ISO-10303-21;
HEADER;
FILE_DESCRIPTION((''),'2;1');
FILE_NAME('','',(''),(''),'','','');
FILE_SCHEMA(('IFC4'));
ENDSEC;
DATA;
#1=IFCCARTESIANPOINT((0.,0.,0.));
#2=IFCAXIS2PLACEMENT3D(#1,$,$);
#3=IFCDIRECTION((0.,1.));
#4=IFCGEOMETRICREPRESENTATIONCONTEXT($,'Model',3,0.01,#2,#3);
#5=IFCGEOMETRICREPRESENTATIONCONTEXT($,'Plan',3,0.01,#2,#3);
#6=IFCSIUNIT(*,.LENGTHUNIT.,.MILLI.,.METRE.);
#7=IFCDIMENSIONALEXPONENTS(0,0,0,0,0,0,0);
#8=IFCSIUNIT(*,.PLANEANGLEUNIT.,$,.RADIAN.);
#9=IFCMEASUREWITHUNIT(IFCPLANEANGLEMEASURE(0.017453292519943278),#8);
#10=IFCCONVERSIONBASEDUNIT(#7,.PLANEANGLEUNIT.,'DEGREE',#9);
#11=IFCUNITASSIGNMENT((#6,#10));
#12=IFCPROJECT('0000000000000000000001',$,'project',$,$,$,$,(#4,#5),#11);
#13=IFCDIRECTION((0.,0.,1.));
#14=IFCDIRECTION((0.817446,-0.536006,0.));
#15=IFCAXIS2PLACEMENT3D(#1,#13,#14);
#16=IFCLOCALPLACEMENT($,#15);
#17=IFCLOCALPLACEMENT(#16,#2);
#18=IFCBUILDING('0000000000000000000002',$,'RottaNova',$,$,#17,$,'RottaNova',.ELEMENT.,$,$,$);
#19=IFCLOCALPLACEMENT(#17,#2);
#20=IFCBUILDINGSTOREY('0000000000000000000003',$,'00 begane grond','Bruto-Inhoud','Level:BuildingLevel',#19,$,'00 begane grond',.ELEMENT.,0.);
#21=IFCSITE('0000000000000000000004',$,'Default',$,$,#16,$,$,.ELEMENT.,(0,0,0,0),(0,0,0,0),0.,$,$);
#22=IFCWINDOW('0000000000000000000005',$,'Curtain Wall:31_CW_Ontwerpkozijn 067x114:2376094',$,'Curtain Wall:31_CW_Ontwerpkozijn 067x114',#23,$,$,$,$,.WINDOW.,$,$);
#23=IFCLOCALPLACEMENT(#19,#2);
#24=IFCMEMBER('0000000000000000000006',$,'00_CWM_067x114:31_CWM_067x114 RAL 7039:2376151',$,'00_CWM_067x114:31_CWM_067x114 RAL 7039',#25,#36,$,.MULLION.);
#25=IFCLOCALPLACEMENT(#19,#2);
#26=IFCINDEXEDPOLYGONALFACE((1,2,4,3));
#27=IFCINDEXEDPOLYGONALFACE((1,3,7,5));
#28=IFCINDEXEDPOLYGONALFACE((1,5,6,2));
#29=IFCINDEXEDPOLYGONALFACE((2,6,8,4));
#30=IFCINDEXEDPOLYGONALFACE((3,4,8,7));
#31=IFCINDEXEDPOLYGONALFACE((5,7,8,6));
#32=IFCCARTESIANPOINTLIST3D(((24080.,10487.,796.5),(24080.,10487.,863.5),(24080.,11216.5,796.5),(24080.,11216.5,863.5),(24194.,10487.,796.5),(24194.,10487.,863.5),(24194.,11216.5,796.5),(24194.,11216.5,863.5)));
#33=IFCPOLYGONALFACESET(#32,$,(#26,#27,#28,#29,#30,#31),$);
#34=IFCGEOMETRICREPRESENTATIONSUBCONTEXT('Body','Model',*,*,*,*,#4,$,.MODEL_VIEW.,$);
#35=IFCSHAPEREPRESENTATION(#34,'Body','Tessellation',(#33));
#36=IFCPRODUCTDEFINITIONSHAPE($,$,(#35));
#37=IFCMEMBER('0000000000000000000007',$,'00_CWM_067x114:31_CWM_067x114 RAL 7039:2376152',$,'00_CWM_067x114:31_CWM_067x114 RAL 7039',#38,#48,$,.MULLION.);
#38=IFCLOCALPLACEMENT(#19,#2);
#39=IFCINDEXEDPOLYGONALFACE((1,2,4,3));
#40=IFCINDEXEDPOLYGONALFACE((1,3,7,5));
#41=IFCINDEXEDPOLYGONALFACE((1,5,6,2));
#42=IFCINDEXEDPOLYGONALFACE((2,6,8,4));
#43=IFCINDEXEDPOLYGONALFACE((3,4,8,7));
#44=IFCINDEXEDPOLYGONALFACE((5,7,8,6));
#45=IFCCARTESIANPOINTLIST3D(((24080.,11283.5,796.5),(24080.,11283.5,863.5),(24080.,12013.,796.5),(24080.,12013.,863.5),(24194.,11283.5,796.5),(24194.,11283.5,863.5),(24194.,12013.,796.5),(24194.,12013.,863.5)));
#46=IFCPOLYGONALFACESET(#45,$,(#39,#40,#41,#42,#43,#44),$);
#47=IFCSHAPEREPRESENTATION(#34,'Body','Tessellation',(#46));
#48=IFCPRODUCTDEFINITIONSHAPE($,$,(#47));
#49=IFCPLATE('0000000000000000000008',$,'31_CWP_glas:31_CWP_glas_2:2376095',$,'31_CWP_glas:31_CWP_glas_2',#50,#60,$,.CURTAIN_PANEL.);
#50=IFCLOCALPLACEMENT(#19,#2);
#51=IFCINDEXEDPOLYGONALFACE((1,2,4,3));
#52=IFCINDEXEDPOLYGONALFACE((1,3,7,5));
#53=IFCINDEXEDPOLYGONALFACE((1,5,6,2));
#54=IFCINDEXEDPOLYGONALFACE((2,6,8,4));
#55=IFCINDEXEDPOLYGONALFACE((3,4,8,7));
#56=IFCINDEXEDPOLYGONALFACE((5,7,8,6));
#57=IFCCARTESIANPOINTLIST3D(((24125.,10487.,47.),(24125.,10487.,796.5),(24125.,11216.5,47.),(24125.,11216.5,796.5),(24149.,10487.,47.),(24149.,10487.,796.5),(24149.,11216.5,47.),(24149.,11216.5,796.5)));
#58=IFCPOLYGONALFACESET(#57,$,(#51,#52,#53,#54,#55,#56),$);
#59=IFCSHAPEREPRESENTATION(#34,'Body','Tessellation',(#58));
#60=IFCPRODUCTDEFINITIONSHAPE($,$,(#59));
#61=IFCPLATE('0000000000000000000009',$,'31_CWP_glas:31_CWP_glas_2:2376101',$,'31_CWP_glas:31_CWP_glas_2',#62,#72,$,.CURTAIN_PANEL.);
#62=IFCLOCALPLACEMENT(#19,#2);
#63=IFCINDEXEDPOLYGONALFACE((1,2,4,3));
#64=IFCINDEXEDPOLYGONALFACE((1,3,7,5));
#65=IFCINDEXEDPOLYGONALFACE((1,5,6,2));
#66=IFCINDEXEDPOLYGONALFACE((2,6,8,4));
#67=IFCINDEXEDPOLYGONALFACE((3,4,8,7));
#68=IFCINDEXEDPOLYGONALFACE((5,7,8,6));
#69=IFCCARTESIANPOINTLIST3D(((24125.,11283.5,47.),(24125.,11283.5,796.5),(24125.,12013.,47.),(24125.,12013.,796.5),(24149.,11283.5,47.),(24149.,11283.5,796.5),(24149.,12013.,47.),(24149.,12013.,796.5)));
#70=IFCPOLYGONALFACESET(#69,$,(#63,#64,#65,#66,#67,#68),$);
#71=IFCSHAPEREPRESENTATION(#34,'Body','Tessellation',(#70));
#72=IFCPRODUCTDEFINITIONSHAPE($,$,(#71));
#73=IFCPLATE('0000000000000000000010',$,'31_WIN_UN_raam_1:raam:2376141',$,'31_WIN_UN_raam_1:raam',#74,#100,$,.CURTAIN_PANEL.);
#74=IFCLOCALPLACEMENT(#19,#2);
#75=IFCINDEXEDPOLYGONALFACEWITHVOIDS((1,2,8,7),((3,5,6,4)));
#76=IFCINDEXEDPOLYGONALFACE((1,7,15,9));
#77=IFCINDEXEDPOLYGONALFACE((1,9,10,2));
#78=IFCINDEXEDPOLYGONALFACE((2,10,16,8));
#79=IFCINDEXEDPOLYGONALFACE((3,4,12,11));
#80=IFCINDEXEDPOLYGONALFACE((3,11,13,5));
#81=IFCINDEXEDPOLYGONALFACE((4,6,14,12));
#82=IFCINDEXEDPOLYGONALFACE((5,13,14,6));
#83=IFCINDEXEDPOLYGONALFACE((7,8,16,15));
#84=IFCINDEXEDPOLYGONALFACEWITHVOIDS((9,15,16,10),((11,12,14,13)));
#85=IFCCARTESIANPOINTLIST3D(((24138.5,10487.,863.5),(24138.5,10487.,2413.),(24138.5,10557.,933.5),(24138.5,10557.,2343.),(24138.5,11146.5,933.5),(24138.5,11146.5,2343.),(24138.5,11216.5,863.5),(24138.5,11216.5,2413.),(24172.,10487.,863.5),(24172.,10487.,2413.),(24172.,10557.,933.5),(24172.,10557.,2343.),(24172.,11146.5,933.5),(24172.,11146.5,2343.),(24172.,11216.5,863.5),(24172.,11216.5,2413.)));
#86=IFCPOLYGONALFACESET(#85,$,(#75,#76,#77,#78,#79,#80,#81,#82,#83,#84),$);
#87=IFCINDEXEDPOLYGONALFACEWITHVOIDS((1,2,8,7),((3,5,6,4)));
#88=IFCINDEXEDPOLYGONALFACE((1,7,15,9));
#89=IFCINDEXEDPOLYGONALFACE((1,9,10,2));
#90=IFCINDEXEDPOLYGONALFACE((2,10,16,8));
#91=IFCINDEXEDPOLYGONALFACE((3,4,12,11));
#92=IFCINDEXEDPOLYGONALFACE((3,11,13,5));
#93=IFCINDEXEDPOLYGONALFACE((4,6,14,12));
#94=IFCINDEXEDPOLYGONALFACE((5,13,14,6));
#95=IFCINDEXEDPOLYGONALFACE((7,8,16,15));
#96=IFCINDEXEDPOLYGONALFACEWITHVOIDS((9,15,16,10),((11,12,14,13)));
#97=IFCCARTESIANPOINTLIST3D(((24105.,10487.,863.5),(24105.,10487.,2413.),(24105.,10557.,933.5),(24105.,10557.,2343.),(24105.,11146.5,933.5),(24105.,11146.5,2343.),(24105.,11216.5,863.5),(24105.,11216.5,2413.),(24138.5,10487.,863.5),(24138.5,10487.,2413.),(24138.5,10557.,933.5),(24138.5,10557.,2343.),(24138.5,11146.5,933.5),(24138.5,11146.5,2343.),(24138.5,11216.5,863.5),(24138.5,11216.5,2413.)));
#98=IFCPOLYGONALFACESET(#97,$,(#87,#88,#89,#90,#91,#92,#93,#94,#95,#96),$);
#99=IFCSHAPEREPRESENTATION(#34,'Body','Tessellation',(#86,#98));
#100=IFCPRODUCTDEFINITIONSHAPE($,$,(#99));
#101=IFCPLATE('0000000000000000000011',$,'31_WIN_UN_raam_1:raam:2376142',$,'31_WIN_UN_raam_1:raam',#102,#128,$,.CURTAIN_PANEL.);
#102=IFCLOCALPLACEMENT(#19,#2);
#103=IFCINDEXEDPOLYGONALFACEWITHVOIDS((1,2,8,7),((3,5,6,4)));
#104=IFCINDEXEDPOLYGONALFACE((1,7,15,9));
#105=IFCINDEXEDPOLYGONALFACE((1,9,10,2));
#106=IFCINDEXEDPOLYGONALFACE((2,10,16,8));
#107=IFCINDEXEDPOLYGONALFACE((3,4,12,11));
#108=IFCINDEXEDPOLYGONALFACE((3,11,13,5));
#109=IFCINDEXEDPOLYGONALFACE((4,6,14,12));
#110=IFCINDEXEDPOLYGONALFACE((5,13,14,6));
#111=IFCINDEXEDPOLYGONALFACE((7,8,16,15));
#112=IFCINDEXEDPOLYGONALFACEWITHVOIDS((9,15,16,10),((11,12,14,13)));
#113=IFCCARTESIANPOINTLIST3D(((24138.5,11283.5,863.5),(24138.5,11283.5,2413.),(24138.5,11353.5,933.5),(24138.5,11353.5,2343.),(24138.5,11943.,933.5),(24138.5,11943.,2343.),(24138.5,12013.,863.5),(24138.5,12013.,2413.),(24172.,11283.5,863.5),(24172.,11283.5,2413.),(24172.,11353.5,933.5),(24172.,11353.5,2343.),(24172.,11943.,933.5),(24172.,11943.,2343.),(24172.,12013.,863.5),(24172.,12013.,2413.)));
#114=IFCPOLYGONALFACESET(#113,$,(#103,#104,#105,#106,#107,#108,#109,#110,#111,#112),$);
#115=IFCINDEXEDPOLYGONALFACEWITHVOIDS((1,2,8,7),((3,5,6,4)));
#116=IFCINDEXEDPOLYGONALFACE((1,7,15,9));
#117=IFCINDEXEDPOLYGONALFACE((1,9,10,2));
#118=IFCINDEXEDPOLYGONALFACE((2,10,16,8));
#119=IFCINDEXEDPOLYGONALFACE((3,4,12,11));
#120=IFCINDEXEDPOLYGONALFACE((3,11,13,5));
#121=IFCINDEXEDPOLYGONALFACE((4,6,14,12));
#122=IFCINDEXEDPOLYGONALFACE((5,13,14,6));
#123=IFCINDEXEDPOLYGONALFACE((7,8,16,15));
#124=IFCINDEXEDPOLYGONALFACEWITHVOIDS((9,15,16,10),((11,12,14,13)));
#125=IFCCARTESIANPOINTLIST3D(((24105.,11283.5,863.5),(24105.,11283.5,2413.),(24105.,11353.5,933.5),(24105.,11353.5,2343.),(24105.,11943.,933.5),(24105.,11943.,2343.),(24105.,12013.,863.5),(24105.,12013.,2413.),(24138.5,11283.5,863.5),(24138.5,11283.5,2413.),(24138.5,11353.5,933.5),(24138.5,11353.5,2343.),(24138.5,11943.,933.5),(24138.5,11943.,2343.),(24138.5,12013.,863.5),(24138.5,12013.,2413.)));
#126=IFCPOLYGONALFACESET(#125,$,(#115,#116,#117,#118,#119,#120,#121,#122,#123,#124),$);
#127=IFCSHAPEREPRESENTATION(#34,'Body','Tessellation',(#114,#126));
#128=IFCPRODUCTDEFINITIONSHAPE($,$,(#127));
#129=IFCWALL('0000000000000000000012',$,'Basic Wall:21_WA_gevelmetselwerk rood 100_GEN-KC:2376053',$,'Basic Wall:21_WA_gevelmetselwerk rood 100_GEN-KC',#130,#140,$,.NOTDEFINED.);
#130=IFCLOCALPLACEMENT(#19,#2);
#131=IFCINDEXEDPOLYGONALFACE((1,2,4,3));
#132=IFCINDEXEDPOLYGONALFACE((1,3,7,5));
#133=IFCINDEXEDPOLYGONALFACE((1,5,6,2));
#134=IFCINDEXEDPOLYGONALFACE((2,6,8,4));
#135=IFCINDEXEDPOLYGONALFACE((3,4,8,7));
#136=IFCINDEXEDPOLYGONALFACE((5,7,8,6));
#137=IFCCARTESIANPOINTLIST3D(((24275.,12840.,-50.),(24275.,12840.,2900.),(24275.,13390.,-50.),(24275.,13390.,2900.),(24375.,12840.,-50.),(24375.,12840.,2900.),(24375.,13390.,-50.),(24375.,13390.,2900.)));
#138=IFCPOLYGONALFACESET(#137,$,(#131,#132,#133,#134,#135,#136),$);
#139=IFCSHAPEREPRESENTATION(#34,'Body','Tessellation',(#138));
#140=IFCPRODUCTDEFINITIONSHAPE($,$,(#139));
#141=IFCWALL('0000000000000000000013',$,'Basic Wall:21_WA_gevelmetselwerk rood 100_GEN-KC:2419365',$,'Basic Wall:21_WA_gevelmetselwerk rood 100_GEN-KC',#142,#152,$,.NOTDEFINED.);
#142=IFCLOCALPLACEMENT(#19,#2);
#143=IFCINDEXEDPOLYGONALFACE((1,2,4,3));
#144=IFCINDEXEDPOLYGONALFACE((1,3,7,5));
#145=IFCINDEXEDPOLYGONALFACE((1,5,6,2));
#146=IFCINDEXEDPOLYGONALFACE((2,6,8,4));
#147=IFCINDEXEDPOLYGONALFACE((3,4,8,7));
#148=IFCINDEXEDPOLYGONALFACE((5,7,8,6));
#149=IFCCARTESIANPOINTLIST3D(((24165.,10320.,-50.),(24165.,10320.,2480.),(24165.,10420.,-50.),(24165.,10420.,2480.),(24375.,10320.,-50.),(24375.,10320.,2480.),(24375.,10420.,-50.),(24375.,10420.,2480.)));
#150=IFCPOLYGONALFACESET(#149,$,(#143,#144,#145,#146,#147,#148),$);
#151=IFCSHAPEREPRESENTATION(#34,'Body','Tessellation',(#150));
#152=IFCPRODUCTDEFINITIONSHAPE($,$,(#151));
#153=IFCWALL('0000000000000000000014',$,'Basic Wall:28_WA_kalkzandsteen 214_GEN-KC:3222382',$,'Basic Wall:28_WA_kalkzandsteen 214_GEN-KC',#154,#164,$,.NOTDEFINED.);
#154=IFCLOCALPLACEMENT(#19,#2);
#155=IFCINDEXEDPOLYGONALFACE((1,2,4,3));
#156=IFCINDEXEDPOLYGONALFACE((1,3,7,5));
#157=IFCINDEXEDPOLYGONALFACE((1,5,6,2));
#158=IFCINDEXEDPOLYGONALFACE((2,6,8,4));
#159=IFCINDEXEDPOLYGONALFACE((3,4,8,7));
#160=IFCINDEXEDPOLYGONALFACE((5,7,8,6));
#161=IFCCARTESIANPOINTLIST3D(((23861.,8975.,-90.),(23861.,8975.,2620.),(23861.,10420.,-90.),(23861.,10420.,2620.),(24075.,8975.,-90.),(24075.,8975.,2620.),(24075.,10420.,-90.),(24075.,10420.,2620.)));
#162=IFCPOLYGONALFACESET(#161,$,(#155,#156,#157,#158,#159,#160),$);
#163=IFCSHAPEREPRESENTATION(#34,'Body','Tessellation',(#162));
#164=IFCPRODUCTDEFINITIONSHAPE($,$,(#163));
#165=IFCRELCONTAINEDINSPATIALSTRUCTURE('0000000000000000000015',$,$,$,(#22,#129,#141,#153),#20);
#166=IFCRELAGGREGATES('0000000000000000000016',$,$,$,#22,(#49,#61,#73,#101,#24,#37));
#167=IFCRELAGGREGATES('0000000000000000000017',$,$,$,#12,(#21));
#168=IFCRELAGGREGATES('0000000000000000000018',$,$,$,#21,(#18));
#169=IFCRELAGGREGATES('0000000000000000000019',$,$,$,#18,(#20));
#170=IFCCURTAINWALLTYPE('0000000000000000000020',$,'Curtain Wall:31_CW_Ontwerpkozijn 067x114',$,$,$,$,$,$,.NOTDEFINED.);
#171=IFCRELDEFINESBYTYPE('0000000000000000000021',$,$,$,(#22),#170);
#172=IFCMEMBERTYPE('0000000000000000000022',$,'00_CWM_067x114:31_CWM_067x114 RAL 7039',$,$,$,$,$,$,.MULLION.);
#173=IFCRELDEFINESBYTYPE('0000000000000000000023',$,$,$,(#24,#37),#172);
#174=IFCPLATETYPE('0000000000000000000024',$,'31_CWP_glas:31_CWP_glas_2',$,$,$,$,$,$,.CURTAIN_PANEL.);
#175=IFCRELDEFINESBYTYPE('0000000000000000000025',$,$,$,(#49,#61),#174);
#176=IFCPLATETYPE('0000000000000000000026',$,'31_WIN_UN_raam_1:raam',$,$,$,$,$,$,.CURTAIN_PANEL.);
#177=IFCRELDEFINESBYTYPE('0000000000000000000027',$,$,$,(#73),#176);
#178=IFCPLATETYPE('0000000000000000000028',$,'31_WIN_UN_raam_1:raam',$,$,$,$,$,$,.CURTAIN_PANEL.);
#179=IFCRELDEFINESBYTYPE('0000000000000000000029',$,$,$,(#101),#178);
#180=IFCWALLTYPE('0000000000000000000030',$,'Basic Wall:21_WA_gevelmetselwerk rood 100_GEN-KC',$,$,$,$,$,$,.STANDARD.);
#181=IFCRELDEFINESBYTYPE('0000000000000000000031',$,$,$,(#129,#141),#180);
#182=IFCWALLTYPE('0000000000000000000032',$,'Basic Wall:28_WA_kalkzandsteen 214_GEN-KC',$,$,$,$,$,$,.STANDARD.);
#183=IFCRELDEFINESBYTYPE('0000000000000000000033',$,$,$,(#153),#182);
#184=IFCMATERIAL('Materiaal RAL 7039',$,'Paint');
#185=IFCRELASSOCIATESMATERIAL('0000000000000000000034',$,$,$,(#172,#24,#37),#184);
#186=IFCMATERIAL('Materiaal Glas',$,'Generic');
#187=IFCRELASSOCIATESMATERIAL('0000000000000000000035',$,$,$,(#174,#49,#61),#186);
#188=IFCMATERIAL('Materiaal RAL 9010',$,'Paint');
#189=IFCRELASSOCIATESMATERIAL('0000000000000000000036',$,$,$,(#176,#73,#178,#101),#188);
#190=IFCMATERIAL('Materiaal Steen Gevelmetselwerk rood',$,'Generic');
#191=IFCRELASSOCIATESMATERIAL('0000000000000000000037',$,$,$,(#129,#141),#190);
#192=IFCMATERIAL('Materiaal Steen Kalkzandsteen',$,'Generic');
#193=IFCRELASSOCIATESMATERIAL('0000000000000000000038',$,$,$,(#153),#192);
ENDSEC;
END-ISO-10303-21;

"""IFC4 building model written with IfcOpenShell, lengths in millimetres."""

from ifc_helpers import new_model, entity, si_unit, converted_unit, direction, frame, origin, place, context, subcontext, project, spatial, indexed_curve, outline, extrude, source, transform, mapped, material, type_object, type_shapes, element, aggregate, save


model = new_model("IFC4")

# Units and contexts
model_context = context("Model", 3, precision=0.01, world=origin(), true_north=direction((0.0, 1.0)))
plan_context = context("Plan", 3, precision=0.01, world=origin(), true_north=direction((0.0, 1.0)))
body_context = subcontext(model_context, "Body", "Model", "MODEL_VIEW")
ifc_project = project(units=[si_unit("LENGTHUNIT", "METRE", prefix="MILLI"), converted_unit("PLANEANGLEUNIT", "DEGREE", entity("IfcPlaneAngleMeasure", 0.017453292519943278), si_unit("PLANEANGLEUNIT", "RADIAN"), dimensions=[0, 0, 0, 0, 0, 0, 0])], contexts=[model_context, plan_context])

# Site, building, storey
site_placement = place(None, frame((0.0, 0.0, 0.0), z_axis=(0.0, 0.0, 1.0), x_axis=(0.817446, -0.536006, 0.0)))
site = spatial("IfcSite", under=ifc_project, at=site_placement, Name="Default", CompositionType="ELEMENT", RefLatitude=(0, 0, 0, 0), RefLongitude=(0, 0, 0, 0), RefElevation=0.0)
building_placement = place(site_placement, origin())
building = spatial("IfcBuilding", under=site, at=building_placement, Name="RottaNova", LongName="RottaNova", CompositionType="ELEMENT")
storey_placement = place(building_placement, origin())
storey = spatial("IfcBuildingStorey", under=building, at=storey_placement, Name="00 begane grond", Description="Bruto-Inhoud", ObjectType="Level:BuildingLevel", LongName="00 begane grond", CompositionType="ELEMENT", Elevation=0.0)

# Window, members, plates
curtain_wall_type = type_object("IfcCurtainWallType", Name="Curtain Wall:31_CW_Ontwerpkozijn 067x114", PredefinedType="NOTDEFINED")
window_placement = place(storey_placement, origin())
window = element("IfcWindow", 1, at=window_placement, inside=storey, type_object=curtain_wall_type, Name="Curtain Wall:31_CW_Ontwerpkozijn 067x114:2376094", ObjectType="Curtain Wall:31_CW_Ontwerpkozijn 067x114", PredefinedType="WINDOW")
ifc_material_1 = material(Name="Materiaal RAL 7039", Category="Paint")
member_type_1 = type_object("IfcMemberType", Name="00_CWM_067x114:31_CWM_067x114 RAL 7039", PredefinedType="MULLION", material=ifc_material_1)
shared_shape_1 = source(origin(), body_context, "Body", "SweptSolid", [
    extrude(outline(indexed_curve([(-33.5, -57.0), (33.5, -57.0), (33.5, 57.0), (-33.5, 57.0), (-33.5, -57.0)], self_intersect=False)), frame((0.0, 57.0, -729.5), z_axis=(0.0, 0.0, 1.0), x_axis=(-1.0, 0.0, 0.0)), (0.0, 0.0, 1.0), 729.5),
])
type_shapes(member_type_1, [shared_shape_1])
member_1_placement = place(window_placement, frame((24080.0, 11216.5, 830.0), z_axis=(0.0, 1.0, 0.0), x_axis=(0.0, 0.0, 1.0)))
member_1 = element("IfcMember", 2, at=member_1_placement, type_object=member_type_1, material=ifc_material_1, Name="00_CWM_067x114:31_CWM_067x114 RAL 7039:2376151", ObjectType="00_CWM_067x114:31_CWM_067x114 RAL 7039", PredefinedType="MULLION", context=body_context, shape_type="MappedRepresentation", body=[
    mapped(shared_shape_1, transform((0.0, 0.0, 0.0), scale=1.0)),
])
member_2_placement = place(window_placement, frame((24080.0, 12013.0, 830.0), z_axis=(0.0, 1.0, 0.0), x_axis=(0.0, 0.0, 1.0)))
member_2 = element("IfcMember", 3, at=member_2_placement, type_object=member_type_1, material=ifc_material_1, Name="00_CWM_067x114:31_CWM_067x114 RAL 7039:2376152", ObjectType="00_CWM_067x114:31_CWM_067x114 RAL 7039", PredefinedType="MULLION", context=body_context, shape_type="MappedRepresentation", body=[
    mapped(shared_shape_1, transform((0.0, 0.0, 0.0), scale=1.0)),
])
ifc_material_2 = material(Name="Materiaal Glas", Category="Generic")
plate_type_1 = type_object("IfcPlateType", Name="31_CWP_glas:31_CWP_glas_2", PredefinedType="CURTAIN_PANEL", material=ifc_material_2)
shared_shape_2 = source(origin(), body_context, "Body", "SweptSolid", [
    extrude(outline(indexed_curve([(-12.0, -364.7), (12.0, -364.7), (12.0, 364.7), (-12.0, 364.7), (-12.0, -364.7)], self_intersect=False)), frame((0.0, -57.0, 0.0), z_axis=(0.0, 0.0, 1.0), x_axis=(0.0, 1.0, 0.0)), (0.0, 0.0, 1.0), 749.5),
])
type_shapes(plate_type_1, [shared_shape_2])
plate_1_placement = place(window_placement, frame((24080.0, 10851.7, 47.0), z_axis=(0.0, 0.0, 1.0), x_axis=(0.0, 1.0, 0.0)))
plate_1 = element("IfcPlate", 4, at=plate_1_placement, type_object=plate_type_1, material=ifc_material_2, Name="31_CWP_glas:31_CWP_glas_2:2376095", ObjectType="31_CWP_glas:31_CWP_glas_2", PredefinedType="CURTAIN_PANEL", context=body_context, shape_type="MappedRepresentation", body=[
    mapped(shared_shape_2, transform((0.0, 0.0, 0.0), scale=1.0)),
])
plate_2_placement = place(window_placement, frame((24080.0, 11648.2, 47.0), z_axis=(0.0, 0.0, 1.0), x_axis=(0.0, 1.0, 0.0)))
plate_2 = element("IfcPlate", 5, at=plate_2_placement, type_object=plate_type_1, material=ifc_material_2, Name="31_CWP_glas:31_CWP_glas_2:2376101", ObjectType="31_CWP_glas:31_CWP_glas_2", PredefinedType="CURTAIN_PANEL", context=body_context, shape_type="MappedRepresentation", body=[
    mapped(shared_shape_2, transform((0.0, 0.0, 0.0), scale=1.0)),
])
ifc_material_3 = material(Name="Materiaal RAL 9010", Category="Paint")
plate_type_2 = type_object("IfcPlateType", Name="31_WIN_UN_raam_1:raam", PredefinedType="CURTAIN_PANEL", material=ifc_material_3)
shared_shape_3 = source(origin(), body_context, "Body", "SweptSolid", [
    extrude(outline(indexed_curve([(-364.7, -774.7), (364.7, -774.7), (364.7, 774.7), (-364.7, 774.7), (-364.7, -774.7)], self_intersect=False), holes=[indexed_curve([(-294.7, 704.7), (294.7, 704.7), (294.7, -704.8), (-294.7, -704.8), (-294.7, 704.7)], self_intersect=False)]), frame((0.0, -92.0, 774.8), z_axis=(0.0, 1.0, 0.0), x_axis=(1.0, 0.0, 0.0)), (0.0, 0.0, 1.0), 33.5),
    extrude(outline(indexed_curve([(-364.7, -774.7), (364.7, -774.7), (364.7, 774.7), (-364.7, 774.7), (-364.7, -774.7)], self_intersect=False), holes=[indexed_curve([(-294.7, 704.7), (294.7, 704.7), (294.7, -704.8), (-294.7, -704.8), (-294.7, 704.7)], self_intersect=False)]), frame((0.0, -58.5, 774.8), z_axis=(0.0, 1.0, 0.0), x_axis=(1.0, 0.0, 0.0)), (0.0, 0.0, 1.0), 33.5),
])
type_shapes(plate_type_2, [shared_shape_3])
plate_3_placement = place(window_placement, frame((24080.0, 10851.7, 863.5), z_axis=(0.0, 0.0, 1.0), x_axis=(0.0, 1.0, 0.0)))
plate_3 = element("IfcPlate", 6, at=plate_3_placement, type_object=plate_type_2, material=ifc_material_3, Name="31_WIN_UN_raam_1:raam:2376141", ObjectType="31_WIN_UN_raam_1:raam", PredefinedType="CURTAIN_PANEL", context=body_context, shape_type="MappedRepresentation", body=[
    mapped(shared_shape_3, transform((0.0, 0.0, 0.0), scale=1.0)),
])
plate_type_3 = type_object("IfcPlateType", Name="31_WIN_UN_raam_1:raam", PredefinedType="CURTAIN_PANEL", material=ifc_material_3)
shared_shape_4 = source(origin(), body_context, "Body", "SweptSolid", [
    extrude(outline(indexed_curve([(-364.7, -774.7), (364.7, -774.7), (364.7, 774.7), (-364.7, 774.7), (-364.7, -774.7)], self_intersect=False), holes=[indexed_curve([(-294.7, 704.7), (294.7, 704.7), (294.7, -704.8), (-294.7, -704.8), (-294.7, 704.7)], self_intersect=False)]), frame((0.0, -92.0, 774.8), z_axis=(0.0, 1.0, 0.0), x_axis=(1.0, 0.0, 0.0)), (0.0, 0.0, 1.0), 33.5),
    extrude(outline(indexed_curve([(-364.7, -774.7), (364.7, -774.7), (364.7, 774.7), (-364.7, 774.7), (-364.7, -774.7)], self_intersect=False), holes=[indexed_curve([(-294.7, 704.7), (294.7, 704.7), (294.7, -704.8), (-294.7, -704.8), (-294.7, 704.7)], self_intersect=False)]), frame((0.0, -58.5, 774.8), z_axis=(0.0, 1.0, 0.0), x_axis=(1.0, 0.0, 0.0)), (0.0, 0.0, 1.0), 33.5),
])
type_shapes(plate_type_3, [shared_shape_4])
plate_4_placement = place(window_placement, frame((24080.0, 11648.2, 863.5), z_axis=(0.0, 0.0, 1.0), x_axis=(0.0, 1.0, 0.0)))
plate_4 = element("IfcPlate", 7, at=plate_4_placement, type_object=plate_type_3, material=ifc_material_3, Name="31_WIN_UN_raam_1:raam:2376142", ObjectType="31_WIN_UN_raam_1:raam", PredefinedType="CURTAIN_PANEL", context=body_context, shape_type="MappedRepresentation", body=[
    mapped(shared_shape_4, transform((0.0, 0.0, 0.0), scale=1.0)),
])
aggregate(window, [plate_1, plate_2, plate_3, plate_4, member_1, member_2])

# Walls
ifc_material_4 = material(Name="Materiaal Steen Gevelmetselwerk rood", Category="Generic")
wall_type_1 = type_object("IfcWallType", Name="Basic Wall:21_WA_gevelmetselwerk rood 100_GEN-KC", PredefinedType="STANDARD")
wall_1_placement = place(storey_placement, frame((24325.0, 12840.0, -50.0), z_axis=(0.0, 0.0, 1.0), x_axis=(0.0, 1.0, 0.0)))
element("IfcWall", 8, at=wall_1_placement, inside=storey, type_object=wall_type_1, material=ifc_material_4, Name="Basic Wall:21_WA_gevelmetselwerk rood 100_GEN-KC:2376053", ObjectType="Basic Wall:21_WA_gevelmetselwerk rood 100_GEN-KC", PredefinedType="NOTDEFINED", context=body_context, shape_type="SweptSolid", body=[
    extrude(outline(indexed_curve([(550.0, 50.0), (0.0, 50.0), (0.0, -50.0), (550.0, -50.0), (550.0, 50.0)], self_intersect=False)), origin(), (0.0, 0.0, 1.0), 2950.0),
])
wall_2_placement = place(storey_placement, frame((24375.0, 10370.0, -50.0), z_axis=(0.0, 0.0, 1.0), x_axis=(-1.0, 0.0, 0.0)))
element("IfcWall", 9, at=wall_2_placement, inside=storey, type_object=wall_type_1, material=ifc_material_4, Name="Basic Wall:21_WA_gevelmetselwerk rood 100_GEN-KC:2419365", ObjectType="Basic Wall:21_WA_gevelmetselwerk rood 100_GEN-KC", PredefinedType="NOTDEFINED", context=body_context, shape_type="SweptSolid", body=[
    extrude(outline(indexed_curve([(210.0, 50.0), (0.0, 50.0), (0.0, -50.0), (210.0, -50.0), (210.0, 50.0)], self_intersect=False)), origin(), (0.0, 0.0, 1.0), 2530.0),
])
ifc_material_5 = material(Name="Materiaal Steen Kalkzandsteen", Category="Generic")
wall_type_2 = type_object("IfcWallType", Name="Basic Wall:28_WA_kalkzandsteen 214_GEN-KC", PredefinedType="STANDARD")
wall_3_placement = place(storey_placement, frame((23968.0, 10420.0, -90.0), z_axis=(0.0, 0.0, 1.0), x_axis=(0.0, -1.0, 0.0)))
element("IfcWall", 10, at=wall_3_placement, inside=storey, type_object=wall_type_2, material=ifc_material_5, Name="Basic Wall:28_WA_kalkzandsteen 214_GEN-KC:3222382", ObjectType="Basic Wall:28_WA_kalkzandsteen 214_GEN-KC", PredefinedType="NOTDEFINED", context=body_context, shape_type="SweptSolid", body=[
    extrude(outline(indexed_curve([(1445.0, 107.0), (0.0, 107.0), (0.0, -107.0), (1445.0, -107.0), (1445.0, 107.0)], self_intersect=False)), origin(), (0.0, 0.0, 1.0), 2710.0),
])

save(model, "model.ifc")
